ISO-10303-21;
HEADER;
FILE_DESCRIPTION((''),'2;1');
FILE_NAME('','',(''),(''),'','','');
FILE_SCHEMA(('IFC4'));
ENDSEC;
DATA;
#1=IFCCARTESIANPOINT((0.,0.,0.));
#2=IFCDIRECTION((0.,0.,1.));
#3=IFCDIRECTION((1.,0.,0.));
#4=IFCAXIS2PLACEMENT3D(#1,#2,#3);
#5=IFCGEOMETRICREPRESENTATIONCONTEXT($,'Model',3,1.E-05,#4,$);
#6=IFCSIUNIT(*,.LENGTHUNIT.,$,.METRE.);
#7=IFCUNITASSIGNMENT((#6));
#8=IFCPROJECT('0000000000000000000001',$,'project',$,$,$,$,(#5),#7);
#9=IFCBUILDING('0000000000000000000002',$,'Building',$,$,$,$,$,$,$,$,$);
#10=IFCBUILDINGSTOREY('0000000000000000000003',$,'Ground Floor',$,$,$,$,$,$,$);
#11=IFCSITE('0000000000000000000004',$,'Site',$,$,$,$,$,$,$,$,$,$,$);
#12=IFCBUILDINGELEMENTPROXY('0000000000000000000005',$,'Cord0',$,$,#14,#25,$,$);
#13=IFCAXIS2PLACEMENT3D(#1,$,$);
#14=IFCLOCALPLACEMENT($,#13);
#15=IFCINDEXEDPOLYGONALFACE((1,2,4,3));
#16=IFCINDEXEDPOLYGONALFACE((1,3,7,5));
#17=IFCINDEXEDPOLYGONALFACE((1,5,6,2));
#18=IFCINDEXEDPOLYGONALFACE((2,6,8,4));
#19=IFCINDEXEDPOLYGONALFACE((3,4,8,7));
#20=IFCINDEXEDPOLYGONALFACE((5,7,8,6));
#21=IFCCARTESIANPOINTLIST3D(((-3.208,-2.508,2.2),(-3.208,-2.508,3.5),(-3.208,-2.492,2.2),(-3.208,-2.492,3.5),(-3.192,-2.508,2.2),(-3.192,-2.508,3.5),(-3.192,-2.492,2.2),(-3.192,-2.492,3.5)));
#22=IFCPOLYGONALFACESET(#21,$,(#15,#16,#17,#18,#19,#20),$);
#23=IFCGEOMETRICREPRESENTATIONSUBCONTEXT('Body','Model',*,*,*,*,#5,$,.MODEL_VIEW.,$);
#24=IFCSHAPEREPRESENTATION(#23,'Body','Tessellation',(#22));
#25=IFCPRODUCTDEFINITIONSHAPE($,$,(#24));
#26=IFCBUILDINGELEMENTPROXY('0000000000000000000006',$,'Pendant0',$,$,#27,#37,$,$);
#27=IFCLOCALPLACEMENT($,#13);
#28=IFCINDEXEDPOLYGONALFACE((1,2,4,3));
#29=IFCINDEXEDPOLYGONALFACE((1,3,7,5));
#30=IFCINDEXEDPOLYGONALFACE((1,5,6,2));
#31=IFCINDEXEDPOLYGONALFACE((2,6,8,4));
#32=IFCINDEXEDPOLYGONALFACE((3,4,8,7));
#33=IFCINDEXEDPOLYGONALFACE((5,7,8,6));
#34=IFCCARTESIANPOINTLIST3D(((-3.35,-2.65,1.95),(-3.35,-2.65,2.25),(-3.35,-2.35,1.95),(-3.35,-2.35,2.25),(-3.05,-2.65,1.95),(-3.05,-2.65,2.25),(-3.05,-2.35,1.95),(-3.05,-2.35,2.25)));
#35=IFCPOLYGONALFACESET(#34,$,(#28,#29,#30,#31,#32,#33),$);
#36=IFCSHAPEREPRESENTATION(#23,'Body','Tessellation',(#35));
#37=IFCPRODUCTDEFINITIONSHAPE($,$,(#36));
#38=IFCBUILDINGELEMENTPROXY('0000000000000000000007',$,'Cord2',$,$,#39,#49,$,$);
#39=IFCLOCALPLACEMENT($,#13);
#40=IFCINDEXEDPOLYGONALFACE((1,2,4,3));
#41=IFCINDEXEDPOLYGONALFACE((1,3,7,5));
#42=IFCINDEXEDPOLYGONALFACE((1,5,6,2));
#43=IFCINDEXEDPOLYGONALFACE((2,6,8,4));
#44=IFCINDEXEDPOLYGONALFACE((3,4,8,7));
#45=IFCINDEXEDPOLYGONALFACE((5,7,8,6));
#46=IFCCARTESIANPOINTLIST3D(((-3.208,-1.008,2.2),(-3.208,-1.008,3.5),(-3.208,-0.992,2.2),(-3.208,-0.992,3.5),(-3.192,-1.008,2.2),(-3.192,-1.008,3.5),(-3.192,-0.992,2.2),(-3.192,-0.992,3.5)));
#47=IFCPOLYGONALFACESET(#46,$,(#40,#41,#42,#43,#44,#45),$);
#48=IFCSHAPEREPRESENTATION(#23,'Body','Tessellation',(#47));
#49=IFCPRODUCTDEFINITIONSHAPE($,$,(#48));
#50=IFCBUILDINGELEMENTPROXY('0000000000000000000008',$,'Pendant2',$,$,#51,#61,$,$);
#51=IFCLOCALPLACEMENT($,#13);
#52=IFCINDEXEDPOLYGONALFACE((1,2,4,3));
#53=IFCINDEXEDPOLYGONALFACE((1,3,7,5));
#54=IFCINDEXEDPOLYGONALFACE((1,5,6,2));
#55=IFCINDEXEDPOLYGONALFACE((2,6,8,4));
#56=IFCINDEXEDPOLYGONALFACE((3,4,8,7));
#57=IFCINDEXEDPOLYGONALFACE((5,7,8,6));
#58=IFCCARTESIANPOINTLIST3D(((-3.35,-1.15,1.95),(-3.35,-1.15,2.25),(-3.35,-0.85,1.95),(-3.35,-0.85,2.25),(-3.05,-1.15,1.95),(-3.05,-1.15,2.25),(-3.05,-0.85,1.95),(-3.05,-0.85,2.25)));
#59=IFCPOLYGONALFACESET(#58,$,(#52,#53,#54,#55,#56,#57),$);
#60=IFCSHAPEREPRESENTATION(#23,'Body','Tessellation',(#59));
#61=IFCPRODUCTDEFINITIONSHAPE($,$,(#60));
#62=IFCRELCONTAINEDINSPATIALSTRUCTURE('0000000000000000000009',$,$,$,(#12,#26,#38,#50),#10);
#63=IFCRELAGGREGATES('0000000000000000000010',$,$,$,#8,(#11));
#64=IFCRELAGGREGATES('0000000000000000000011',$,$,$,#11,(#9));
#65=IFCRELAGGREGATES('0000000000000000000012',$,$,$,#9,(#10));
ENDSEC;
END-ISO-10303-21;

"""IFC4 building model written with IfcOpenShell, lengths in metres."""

from ifc_helpers import new_model, si_unit, frame, origin_with_axes, origin_2d, place, context, subcontext, project, spatial, rectangle, extrude, element, save


model = new_model("IFC4")

# Units and contexts
model_context = context("Model", 3, precision=1e-05, world=origin_with_axes())
body_context = subcontext(model_context, "Body", "Model", "MODEL_VIEW")
ifc_project = project(units=[si_unit("LENGTHUNIT", "METRE")], contexts=[model_context])

# Site, building, storey
site = spatial("IfcSite", under=ifc_project, Name="Site")
building = spatial("IfcBuilding", under=site, Name="Building")
storey = spatial("IfcBuildingStorey", under=building, Name="Ground Floor")

# Building element proxies
proxy_1_placement = place(None, frame((-3.2, -2.5, 2.85), z_axis=(0.0, 0.0, 1.0), x_axis=(1.0, 0.0, 0.0)))
element("IfcBuildingElementProxy", 1, at=proxy_1_placement, inside=storey, Name="Cord0", context=body_context, shape_type="SweptSolid", body=[
    extrude(rectangle(XDim=0.016, YDim=0.016, at=origin_2d()), frame((0.0, 0.0, -0.65)), (0.0, 0.0, 1.0), 1.3),
])
proxy_2_placement = place(None, frame((-3.2, -2.5, 2.1), z_axis=(0.0, 0.0, 1.0), x_axis=(1.0, 0.0, 0.0)))
element("IfcBuildingElementProxy", 2, at=proxy_2_placement, inside=storey, Name="Pendant0", context=body_context, shape_type="SweptSolid", body=[
    extrude(rectangle(XDim=0.3, YDim=0.3, at=origin_2d()), frame((0.0, 0.0, -0.15)), (0.0, 0.0, 1.0), 0.3),
])
proxy_3_placement = place(None, frame((-3.2, -1.0, 2.85), z_axis=(0.0, 0.0, 1.0), x_axis=(1.0, 0.0, 0.0)))
element("IfcBuildingElementProxy", 3, at=proxy_3_placement, inside=storey, Name="Cord2", context=body_context, shape_type="SweptSolid", body=[
    extrude(rectangle(XDim=0.016, YDim=0.016, at=origin_2d()), frame((0.0, 0.0, -0.65)), (0.0, 0.0, 1.0), 1.3),
])
proxy_4_placement = place(None, frame((-3.2, -1.0, 2.1), z_axis=(0.0, 0.0, 1.0), x_axis=(1.0, 0.0, 0.0)))
element("IfcBuildingElementProxy", 4, at=proxy_4_placement, inside=storey, Name="Pendant2", context=body_context, shape_type="SweptSolid", body=[
    extrude(rectangle(XDim=0.3, YDim=0.3, at=origin_2d()), frame((0.0, 0.0, -0.15)), (0.0, 0.0, 1.0), 0.3),
])

save(model, "model.ifc")
